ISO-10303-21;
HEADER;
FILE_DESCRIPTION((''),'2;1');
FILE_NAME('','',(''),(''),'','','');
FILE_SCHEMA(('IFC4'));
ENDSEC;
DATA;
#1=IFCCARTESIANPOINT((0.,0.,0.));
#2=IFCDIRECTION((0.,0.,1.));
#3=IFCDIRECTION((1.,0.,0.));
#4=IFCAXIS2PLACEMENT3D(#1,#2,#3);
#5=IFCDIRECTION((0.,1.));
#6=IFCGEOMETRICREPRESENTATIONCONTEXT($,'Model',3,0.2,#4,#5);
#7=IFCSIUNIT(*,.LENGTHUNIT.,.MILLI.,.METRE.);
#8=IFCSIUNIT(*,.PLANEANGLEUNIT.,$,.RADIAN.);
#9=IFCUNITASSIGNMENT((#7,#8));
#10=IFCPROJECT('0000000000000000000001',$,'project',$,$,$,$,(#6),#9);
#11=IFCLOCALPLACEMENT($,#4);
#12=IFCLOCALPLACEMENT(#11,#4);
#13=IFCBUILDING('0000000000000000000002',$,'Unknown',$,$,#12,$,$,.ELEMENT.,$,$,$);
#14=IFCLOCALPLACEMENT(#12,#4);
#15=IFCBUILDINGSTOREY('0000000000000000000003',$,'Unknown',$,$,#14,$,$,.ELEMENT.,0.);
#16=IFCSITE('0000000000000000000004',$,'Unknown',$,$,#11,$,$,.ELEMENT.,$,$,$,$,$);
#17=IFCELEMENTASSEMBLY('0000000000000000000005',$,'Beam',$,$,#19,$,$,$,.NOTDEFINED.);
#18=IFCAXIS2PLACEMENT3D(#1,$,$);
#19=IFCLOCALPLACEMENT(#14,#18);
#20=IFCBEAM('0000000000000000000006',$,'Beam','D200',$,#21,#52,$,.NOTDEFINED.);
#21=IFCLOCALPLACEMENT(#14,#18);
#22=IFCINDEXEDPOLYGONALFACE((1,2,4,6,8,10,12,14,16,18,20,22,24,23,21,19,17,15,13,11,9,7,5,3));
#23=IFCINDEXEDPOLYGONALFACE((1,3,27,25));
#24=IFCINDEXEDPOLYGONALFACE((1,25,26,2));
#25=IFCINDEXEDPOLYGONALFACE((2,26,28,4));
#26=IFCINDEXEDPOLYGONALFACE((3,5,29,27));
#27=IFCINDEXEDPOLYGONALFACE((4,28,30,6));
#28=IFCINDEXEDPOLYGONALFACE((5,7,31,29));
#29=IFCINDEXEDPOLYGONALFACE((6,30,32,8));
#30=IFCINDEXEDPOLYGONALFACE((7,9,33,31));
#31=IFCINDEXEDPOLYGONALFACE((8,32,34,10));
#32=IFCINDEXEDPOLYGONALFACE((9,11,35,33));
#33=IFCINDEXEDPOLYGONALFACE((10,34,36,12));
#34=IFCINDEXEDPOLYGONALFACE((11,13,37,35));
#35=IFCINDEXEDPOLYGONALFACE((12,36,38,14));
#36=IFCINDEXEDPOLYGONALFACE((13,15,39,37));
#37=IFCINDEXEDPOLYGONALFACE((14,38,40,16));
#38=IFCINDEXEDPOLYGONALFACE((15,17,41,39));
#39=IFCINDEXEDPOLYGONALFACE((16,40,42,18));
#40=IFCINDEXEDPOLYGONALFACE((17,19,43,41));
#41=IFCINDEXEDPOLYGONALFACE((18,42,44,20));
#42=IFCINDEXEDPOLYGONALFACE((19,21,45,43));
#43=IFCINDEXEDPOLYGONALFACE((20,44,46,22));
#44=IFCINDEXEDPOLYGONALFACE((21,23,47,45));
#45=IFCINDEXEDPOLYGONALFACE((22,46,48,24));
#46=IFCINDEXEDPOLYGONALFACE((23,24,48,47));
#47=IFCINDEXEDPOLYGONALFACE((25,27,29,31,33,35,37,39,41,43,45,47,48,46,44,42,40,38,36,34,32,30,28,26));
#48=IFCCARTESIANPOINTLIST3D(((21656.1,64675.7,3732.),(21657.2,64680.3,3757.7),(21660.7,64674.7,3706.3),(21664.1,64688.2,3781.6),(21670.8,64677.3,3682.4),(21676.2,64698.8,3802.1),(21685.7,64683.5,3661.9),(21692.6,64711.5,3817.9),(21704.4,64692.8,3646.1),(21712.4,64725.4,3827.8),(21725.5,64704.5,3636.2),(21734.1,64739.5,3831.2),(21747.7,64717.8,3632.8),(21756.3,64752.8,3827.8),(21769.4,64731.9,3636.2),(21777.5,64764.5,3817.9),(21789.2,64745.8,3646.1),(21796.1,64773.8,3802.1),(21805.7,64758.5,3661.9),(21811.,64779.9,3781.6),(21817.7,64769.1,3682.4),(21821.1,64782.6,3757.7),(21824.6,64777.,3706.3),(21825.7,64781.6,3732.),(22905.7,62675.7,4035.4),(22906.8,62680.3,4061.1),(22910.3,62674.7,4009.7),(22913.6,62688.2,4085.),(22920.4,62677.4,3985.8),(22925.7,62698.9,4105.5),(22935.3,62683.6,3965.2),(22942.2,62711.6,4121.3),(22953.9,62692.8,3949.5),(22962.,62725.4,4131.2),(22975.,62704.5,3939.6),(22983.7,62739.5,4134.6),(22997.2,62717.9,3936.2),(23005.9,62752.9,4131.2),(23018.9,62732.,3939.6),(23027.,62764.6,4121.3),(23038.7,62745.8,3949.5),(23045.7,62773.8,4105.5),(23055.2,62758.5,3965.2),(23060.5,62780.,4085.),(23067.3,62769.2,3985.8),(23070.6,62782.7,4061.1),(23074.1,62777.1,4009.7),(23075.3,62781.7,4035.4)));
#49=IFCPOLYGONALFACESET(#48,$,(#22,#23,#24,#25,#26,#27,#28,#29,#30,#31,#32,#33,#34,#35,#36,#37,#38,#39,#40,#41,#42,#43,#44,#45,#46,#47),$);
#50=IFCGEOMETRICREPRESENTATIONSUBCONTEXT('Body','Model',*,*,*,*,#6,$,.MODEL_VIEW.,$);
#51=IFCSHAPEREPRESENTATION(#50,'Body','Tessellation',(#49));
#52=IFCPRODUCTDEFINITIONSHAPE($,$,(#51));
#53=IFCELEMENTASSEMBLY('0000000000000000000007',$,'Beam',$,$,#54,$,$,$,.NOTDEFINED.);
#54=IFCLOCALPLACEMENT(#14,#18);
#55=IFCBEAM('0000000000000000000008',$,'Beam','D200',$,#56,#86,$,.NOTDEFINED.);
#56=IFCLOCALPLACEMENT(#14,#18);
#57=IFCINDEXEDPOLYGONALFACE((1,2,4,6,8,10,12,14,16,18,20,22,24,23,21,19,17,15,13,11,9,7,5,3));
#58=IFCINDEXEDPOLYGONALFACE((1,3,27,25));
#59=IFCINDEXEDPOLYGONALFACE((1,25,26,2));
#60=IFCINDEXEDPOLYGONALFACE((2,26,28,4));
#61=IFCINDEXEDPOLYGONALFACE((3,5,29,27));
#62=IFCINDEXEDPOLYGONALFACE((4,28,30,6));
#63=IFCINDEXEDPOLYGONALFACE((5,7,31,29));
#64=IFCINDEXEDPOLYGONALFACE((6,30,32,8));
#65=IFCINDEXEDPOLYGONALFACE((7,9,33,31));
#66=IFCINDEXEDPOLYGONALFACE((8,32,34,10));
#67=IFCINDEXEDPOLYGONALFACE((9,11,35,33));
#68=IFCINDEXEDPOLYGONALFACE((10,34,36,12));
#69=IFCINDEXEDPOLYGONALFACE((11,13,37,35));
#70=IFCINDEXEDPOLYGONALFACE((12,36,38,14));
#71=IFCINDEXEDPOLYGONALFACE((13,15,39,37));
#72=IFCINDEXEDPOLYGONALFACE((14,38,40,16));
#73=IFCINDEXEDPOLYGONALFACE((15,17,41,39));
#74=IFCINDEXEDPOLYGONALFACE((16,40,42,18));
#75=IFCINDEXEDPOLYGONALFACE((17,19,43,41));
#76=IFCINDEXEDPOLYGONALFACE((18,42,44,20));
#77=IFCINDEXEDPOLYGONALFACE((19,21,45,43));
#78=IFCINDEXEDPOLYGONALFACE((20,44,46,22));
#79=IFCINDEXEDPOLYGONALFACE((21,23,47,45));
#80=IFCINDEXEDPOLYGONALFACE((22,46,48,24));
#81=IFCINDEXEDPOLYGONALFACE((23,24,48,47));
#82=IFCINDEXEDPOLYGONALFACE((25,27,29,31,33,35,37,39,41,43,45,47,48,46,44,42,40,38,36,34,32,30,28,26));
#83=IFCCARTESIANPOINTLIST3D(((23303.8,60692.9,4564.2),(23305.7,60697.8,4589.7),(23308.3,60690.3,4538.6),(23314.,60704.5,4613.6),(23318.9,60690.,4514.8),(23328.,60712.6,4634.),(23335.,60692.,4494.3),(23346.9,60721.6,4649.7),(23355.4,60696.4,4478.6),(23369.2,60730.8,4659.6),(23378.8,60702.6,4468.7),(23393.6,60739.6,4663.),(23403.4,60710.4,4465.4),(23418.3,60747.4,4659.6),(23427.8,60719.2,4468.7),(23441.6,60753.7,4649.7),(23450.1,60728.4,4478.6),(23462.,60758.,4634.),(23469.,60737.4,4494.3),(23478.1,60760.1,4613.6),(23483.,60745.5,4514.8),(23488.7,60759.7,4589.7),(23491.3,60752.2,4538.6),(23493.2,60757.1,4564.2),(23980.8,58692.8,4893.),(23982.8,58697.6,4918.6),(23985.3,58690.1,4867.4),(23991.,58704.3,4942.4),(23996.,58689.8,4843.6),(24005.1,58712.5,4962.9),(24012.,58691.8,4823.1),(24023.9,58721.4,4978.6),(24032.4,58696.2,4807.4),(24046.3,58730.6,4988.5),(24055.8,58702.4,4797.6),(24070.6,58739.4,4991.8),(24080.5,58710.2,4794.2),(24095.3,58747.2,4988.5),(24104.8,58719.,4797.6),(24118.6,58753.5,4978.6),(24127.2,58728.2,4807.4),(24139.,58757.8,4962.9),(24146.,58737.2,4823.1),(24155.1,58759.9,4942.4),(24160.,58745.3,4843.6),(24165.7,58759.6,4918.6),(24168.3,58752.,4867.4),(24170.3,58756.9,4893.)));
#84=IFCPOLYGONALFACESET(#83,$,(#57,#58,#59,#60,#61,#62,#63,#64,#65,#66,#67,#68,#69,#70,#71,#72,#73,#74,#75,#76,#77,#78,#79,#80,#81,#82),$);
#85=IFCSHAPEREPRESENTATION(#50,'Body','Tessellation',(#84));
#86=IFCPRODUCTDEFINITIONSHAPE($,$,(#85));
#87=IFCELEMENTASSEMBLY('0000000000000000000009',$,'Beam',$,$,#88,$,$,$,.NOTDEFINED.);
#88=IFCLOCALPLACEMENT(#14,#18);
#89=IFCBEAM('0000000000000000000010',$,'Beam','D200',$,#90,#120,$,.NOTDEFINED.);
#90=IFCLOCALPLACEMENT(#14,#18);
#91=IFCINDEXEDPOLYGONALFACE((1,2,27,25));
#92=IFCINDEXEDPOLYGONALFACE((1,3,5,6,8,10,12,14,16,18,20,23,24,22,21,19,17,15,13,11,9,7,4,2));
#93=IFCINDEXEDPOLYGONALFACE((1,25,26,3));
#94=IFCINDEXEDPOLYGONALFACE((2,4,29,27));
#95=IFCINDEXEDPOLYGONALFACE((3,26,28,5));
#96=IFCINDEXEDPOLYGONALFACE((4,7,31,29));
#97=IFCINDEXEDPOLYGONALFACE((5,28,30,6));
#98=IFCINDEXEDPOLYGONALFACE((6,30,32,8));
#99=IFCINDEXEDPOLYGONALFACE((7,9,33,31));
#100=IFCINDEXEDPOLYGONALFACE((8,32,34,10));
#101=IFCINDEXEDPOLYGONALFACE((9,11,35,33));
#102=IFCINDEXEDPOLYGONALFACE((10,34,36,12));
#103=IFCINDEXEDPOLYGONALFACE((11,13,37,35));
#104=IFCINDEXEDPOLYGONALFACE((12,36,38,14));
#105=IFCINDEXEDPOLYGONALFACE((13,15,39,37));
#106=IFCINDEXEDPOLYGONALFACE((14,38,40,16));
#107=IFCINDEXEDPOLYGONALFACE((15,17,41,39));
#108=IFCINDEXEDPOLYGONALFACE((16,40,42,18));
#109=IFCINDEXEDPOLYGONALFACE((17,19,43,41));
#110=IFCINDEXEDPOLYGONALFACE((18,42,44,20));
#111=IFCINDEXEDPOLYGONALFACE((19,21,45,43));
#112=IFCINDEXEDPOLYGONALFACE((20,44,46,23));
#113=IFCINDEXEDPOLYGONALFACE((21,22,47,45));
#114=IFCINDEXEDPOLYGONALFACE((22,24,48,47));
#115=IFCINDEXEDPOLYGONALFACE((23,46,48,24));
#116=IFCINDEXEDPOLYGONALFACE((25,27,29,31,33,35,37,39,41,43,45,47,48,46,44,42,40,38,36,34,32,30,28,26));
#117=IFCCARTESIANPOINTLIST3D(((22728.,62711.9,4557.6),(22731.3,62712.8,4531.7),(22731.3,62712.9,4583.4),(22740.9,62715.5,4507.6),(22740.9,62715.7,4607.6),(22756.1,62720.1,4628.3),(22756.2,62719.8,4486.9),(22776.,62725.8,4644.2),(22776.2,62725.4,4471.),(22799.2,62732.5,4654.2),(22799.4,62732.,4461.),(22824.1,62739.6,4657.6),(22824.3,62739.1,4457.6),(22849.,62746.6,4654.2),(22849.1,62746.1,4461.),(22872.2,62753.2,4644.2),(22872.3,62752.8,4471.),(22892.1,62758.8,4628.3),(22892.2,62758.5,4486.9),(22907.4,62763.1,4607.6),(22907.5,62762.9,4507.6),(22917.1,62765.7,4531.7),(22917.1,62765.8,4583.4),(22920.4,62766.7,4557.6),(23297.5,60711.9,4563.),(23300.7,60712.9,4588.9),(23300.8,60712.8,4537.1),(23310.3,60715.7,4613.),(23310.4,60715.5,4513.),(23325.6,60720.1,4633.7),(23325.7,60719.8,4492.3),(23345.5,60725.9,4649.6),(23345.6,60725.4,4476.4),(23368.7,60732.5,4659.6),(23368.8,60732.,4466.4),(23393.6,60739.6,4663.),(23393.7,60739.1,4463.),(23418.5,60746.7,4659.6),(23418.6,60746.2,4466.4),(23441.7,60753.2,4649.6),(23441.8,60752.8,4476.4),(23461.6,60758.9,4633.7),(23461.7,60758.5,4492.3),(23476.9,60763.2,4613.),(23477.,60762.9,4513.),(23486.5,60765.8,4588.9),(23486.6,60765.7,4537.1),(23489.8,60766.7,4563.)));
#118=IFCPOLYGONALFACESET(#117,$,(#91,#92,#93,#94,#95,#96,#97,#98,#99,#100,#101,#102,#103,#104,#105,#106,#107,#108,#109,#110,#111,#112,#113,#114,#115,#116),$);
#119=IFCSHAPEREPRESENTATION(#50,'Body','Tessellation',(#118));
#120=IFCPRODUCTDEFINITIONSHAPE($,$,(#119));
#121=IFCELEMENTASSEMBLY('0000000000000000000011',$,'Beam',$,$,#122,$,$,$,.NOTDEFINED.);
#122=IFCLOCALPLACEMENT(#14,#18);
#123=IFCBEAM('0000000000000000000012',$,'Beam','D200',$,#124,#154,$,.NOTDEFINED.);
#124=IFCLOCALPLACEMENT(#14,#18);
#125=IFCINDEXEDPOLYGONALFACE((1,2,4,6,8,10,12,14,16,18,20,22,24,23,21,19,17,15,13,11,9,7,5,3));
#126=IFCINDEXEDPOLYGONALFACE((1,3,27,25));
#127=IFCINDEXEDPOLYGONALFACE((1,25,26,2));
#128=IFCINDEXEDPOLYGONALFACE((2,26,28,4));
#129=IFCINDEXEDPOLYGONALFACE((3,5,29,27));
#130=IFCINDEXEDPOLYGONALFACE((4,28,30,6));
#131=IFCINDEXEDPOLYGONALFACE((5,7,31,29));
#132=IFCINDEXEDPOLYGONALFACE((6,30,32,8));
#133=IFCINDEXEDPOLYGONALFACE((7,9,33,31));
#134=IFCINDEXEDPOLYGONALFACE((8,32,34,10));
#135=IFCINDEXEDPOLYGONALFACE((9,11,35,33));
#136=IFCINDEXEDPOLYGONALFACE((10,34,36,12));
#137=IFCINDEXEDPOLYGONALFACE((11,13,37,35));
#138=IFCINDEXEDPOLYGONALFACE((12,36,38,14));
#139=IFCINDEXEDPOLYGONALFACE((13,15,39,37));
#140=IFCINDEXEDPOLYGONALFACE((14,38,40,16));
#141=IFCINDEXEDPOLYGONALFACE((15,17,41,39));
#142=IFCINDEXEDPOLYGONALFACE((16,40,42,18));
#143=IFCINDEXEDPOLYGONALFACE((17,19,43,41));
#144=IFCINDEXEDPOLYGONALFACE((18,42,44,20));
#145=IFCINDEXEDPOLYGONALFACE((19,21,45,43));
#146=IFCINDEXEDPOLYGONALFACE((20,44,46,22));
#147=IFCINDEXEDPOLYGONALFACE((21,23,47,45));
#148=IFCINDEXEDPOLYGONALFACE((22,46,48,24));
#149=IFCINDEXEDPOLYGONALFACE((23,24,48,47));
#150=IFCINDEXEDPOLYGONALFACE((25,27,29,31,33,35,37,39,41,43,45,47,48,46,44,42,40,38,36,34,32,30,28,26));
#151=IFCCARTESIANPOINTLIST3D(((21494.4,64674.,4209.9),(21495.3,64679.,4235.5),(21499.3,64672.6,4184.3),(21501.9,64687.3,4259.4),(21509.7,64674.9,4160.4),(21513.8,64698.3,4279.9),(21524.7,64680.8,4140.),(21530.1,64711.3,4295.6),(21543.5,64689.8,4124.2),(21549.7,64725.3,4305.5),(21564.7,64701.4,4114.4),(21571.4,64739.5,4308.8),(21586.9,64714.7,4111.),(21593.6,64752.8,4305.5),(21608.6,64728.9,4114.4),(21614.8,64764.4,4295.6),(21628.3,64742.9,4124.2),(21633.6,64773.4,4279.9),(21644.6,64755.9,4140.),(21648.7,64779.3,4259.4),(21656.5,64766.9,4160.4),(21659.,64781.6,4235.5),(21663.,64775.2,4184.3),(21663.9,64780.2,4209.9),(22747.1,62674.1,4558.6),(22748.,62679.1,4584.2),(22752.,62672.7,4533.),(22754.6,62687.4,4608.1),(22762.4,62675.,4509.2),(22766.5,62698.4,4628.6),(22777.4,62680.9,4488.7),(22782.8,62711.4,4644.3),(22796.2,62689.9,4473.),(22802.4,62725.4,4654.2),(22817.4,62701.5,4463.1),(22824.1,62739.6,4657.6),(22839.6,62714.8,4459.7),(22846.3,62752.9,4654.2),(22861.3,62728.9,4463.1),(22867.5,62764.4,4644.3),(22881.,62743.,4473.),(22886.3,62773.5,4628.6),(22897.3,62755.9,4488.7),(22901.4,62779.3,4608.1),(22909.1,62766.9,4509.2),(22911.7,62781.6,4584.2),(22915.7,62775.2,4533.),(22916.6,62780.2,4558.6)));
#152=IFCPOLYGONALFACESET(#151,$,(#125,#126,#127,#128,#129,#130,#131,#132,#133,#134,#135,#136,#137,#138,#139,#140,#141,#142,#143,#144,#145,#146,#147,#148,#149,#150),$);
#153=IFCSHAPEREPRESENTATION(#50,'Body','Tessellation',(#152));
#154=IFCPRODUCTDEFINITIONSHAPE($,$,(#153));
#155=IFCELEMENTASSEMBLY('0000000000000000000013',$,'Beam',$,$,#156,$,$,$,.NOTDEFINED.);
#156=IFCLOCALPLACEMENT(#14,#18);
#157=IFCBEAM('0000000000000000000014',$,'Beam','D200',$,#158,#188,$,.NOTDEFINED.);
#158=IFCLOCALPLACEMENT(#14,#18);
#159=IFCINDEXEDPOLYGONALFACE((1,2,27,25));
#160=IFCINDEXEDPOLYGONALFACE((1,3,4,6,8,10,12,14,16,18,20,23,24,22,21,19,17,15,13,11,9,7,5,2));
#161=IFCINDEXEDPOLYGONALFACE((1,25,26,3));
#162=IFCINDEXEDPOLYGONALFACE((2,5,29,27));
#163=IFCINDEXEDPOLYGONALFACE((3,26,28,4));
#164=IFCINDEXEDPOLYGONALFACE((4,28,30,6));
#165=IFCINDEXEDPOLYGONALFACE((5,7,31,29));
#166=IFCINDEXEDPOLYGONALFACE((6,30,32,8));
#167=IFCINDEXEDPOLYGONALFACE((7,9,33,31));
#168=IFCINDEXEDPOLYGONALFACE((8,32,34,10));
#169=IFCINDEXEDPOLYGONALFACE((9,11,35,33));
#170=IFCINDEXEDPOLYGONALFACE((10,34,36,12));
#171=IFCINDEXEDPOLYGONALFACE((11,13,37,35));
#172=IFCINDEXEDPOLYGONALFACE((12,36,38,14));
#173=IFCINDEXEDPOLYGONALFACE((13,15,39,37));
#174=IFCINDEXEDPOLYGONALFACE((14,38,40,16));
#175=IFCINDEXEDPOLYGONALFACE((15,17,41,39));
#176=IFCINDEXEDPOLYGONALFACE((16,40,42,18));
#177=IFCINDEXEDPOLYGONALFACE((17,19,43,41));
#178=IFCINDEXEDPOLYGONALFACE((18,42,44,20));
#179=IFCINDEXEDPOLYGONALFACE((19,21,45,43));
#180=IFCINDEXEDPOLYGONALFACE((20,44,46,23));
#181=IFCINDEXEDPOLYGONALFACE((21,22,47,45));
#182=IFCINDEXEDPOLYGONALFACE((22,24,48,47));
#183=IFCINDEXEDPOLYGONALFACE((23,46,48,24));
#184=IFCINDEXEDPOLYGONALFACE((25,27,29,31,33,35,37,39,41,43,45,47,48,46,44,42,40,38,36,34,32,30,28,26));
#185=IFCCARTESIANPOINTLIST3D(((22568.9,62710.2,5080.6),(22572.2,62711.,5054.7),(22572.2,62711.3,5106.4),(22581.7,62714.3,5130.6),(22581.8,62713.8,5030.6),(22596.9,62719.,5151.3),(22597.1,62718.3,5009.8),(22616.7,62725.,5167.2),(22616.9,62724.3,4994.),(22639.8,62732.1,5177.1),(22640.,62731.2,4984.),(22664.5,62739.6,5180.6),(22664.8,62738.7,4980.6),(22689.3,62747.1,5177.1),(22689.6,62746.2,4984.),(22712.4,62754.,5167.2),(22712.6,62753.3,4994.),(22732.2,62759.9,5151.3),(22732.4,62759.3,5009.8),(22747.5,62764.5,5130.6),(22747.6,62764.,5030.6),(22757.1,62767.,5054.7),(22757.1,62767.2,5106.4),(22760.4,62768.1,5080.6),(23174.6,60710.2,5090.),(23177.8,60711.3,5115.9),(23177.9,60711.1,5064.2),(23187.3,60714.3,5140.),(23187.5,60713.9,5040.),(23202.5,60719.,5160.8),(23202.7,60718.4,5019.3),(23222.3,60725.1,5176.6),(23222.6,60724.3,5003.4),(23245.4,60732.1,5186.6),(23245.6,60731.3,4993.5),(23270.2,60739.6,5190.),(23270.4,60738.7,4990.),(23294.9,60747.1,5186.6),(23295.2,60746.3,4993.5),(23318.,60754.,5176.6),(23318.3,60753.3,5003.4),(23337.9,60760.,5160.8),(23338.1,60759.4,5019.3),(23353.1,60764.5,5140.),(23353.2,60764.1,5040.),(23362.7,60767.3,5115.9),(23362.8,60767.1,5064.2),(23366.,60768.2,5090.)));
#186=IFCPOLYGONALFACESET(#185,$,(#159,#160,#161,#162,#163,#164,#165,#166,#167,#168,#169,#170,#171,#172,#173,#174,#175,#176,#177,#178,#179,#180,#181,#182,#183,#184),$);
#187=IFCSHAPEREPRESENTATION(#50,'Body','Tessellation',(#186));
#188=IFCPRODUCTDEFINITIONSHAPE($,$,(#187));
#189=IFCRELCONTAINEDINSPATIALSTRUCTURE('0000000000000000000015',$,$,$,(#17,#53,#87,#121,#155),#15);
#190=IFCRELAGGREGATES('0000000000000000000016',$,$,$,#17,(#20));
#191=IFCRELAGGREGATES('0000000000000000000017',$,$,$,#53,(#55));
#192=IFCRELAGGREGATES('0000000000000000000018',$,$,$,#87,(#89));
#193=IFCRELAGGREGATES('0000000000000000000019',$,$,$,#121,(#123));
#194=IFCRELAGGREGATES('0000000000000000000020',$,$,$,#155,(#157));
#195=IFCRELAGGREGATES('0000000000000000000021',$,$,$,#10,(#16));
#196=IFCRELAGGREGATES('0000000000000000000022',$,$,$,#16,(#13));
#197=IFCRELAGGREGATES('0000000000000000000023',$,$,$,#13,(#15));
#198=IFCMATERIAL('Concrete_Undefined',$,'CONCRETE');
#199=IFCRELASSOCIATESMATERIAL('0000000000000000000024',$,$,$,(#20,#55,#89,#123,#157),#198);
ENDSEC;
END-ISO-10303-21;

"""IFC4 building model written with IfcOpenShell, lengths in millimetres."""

from ifc_helpers import new_model, si_unit, direction, frame, origin_with_axes, place, context, subcontext, project, spatial, line, indexed_curve, outline, extrude, material, element, aggregate, save


model = new_model("IFC4")

# Units and contexts
model_context = context("Model", 3, precision=0.2, world=origin_with_axes(), true_north=direction((0.0, 1.0)))
body_context = subcontext(model_context, "Body", "Model", "MODEL_VIEW")
ifc_project = project(units=[si_unit("LENGTHUNIT", "METRE", prefix="MILLI"), si_unit("PLANEANGLEUNIT", "RADIAN")], contexts=[model_context])

# Site, building, storey
site_placement = place(None, origin_with_axes())
site = spatial("IfcSite", under=ifc_project, at=site_placement, Name="Unknown", CompositionType="ELEMENT")
building_placement = place(site_placement, origin_with_axes())
building = spatial("IfcBuilding", under=site, at=building_placement, Name="Unknown", CompositionType="ELEMENT")
storey_placement = place(building_placement, origin_with_axes())
storey = spatial("IfcBuildingStorey", under=building, at=storey_placement, Name="Unknown", CompositionType="ELEMENT", Elevation=0.0)

# Element assemblies, beams
ifc_material = material(Name="Concrete_Undefined", Category="CONCRETE")
assembly_1_placement = place(storey_placement, frame((21740.9, 64728.6, 3732.0), z_axis=(-0.848074, -0.529878, 0.0), x_axis=(0.525546, -0.841141, 0.127603)))
assembly_1 = element("IfcElementAssembly", 1, at=assembly_1_placement, inside=storey, Name="Beam", PredefinedType="NOTDEFINED")
beam_1_placement = place(assembly_1_placement, origin_with_axes())
beam_1 = element("IfcBeam", 2, at=beam_1_placement, material=ifc_material, Name="Beam", Description="D200", PredefinedType="NOTDEFINED", context=body_context, shape_type="SolidModel", body=[
    extrude(outline(indexed_curve([(100.0, 0.0), (96.6, 25.9), (86.6, 50.0), (70.7, 70.7), (50.0, 86.6), (25.9, 96.6), (0.0, 100.0), (-25.9, 96.6), (-50.0, 86.6), (-70.7, 70.7), (-86.6, 50.0), (-96.6, 25.9), (-100.0, 0.0), (-96.6, -25.9), (-86.6, -50.0), (-70.7, -70.7), (-50.0, -86.6), (-25.9, -96.6), (0.0, -100.0), (25.9, -96.6), (50.0, -86.6), (70.7, -70.7), (86.6, -50.0), (96.6, -25.9)], segments=[line(1, 2, 3, 4, 5, 6, 7, 8, 9, 10, 11, 12, 13, 14, 15, 16, 17, 18, 19, 20, 21, 22, 23, 24, 1)])), frame((0.0, 0.0, 0.0), z_axis=(-1.0, 0.0, 0.0), x_axis=(0.0, 0.0, 1.0)), (0.0, 0.0, -1.0), 2377.6),
])
aggregate(assembly_1, [beam_1])
assembly_2_placement = place(storey_placement, frame((23398.5, 60725.0, 4564.2), z_axis=(-0.947211, -0.32061, 0.0), x_axis=(0.316791, -0.93593, 0.153875)))
assembly_2 = element("IfcElementAssembly", 3, at=assembly_2_placement, inside=storey, Name="Beam", PredefinedType="NOTDEFINED")
beam_2_placement = place(assembly_2_placement, origin_with_axes())
beam_2 = element("IfcBeam", 4, at=beam_2_placement, material=ifc_material, Name="Beam", Description="D200", PredefinedType="NOTDEFINED", context=body_context, shape_type="SolidModel", body=[
    extrude(outline(indexed_curve([(100.0, 0.0), (96.6, 25.9), (86.6, 50.0), (70.7, 70.7), (50.0, 86.6), (25.9, 96.6), (0.0, 100.0), (-25.9, 96.6), (-50.0, 86.6), (-70.7, 70.7), (-86.6, 50.0), (-96.6, 25.9), (-100.0, 0.0), (-96.6, -25.9), (-86.6, -50.0), (-70.7, -70.7), (-50.0, -86.6), (-25.9, -96.6), (0.0, -100.0), (25.9, -96.6), (50.0, -86.6), (70.7, -70.7), (86.6, -50.0), (96.6, -25.9)], segments=[line(1, 2, 3, 4, 5, 6, 7, 8, 9, 10, 11, 12, 13, 14, 15, 16, 17, 18, 19, 20, 21, 22, 23, 24, 1)])), frame((0.0, 0.0, 0.0), z_axis=(-1.0, 0.0, 0.0), x_axis=(0.0, 0.0, 1.0)), (0.0, 0.0, -1.0), 2137.1),
])
aggregate(assembly_2, [beam_2])
assembly_3_placement = place(storey_placement, frame((22824.2, 62739.3, 4557.6), z_axis=(-0.961772, -0.273852, 0.0), x_axis=(0.273851, -0.961769, 0.002601)))
assembly_3 = element("IfcElementAssembly", 5, at=assembly_3_placement, inside=storey, Name="Beam", PredefinedType="NOTDEFINED")
beam_3_placement = place(assembly_3_placement, origin_with_axes())
beam_3 = element("IfcBeam", 6, at=beam_3_placement, material=ifc_material, Name="Beam", Description="D200", PredefinedType="NOTDEFINED", context=body_context, shape_type="SolidModel", body=[
    extrude(outline(indexed_curve([(100.0, 0.0), (96.6, 25.9), (86.6, 50.0), (70.7, 70.7), (50.0, 86.6), (25.9, 96.6), (0.0, 100.0), (-25.9, 96.6), (-50.0, 86.6), (-70.7, 70.7), (-86.6, 50.0), (-96.6, 25.9), (-100.0, 0.0), (-96.6, -25.9), (-86.6, -50.0), (-70.7, -70.7), (-50.0, -86.6), (-25.9, -96.6), (0.0, -100.0), (25.9, -96.6), (50.0, -86.6), (70.7, -70.7), (86.6, -50.0), (96.6, -25.9)], segments=[line(1, 2, 3, 4, 5, 6, 7, 8, 9, 10, 11, 12, 13, 14, 15, 16, 17, 18, 19, 20, 21, 22, 23, 24, 1)])), frame((0.0, 0.0, 0.0), z_axis=(-1.0, 0.0, 0.0), x_axis=(0.0, 0.0, 1.0)), (0.0, 0.0, -1.0), 2079.5),
])
aggregate(assembly_3, [beam_3])
assembly_4_placement = place(storey_placement, frame((21579.2, 64727.1, 4209.9), z_axis=(-0.847475, -0.530836, 0.0), x_axis=(0.525133, -0.83837, 0.146187)))
assembly_4 = element("IfcElementAssembly", 7, at=assembly_4_placement, inside=storey, Name="Beam", PredefinedType="NOTDEFINED")
beam_4_placement = place(assembly_4_placement, origin_with_axes())
beam_4 = element("IfcBeam", 8, at=beam_4_placement, material=ifc_material, Name="Beam", Description="D200", PredefinedType="NOTDEFINED", context=body_context, shape_type="SolidModel", body=[
    extrude(outline(indexed_curve([(100.0, 0.0), (96.6, 25.9), (86.6, 50.0), (70.7, 70.7), (50.0, 86.6), (25.9, 96.6), (0.0, 100.0), (-25.9, 96.6), (-50.0, 86.6), (-70.7, 70.7), (-86.6, 50.0), (-96.6, 25.9), (-100.0, 0.0), (-96.6, -25.9), (-86.6, -50.0), (-70.7, -70.7), (-50.0, -86.6), (-25.9, -96.6), (0.0, -100.0), (25.9, -96.6), (50.0, -86.6), (70.7, -70.7), (86.6, -50.0), (96.6, -25.9)], segments=[line(1, 2, 3, 4, 5, 6, 7, 8, 9, 10, 11, 12, 13, 14, 15, 16, 17, 18, 19, 20, 21, 22, 23, 24, 1)])), frame((0.0, 0.0, 0.0), z_axis=(-1.0, 0.0, 0.0), x_axis=(0.0, 0.0, 1.0)), (0.0, 0.0, -1.0), 2385.5),
])
aggregate(assembly_4, [beam_4])
assembly_5_placement = place(storey_placement, frame((22664.7, 62739.1, 5080.6), z_axis=(-0.957079, -0.289827, 0.0), x_axis=(0.289824, -0.957069, 0.00454)))
assembly_5 = element("IfcElementAssembly", 9, at=assembly_5_placement, inside=storey, Name="Beam", PredefinedType="NOTDEFINED")
beam_5_placement = place(assembly_5_placement, origin_with_axes())
beam_5 = element("IfcBeam", 10, at=beam_5_placement, material=ifc_material, Name="Beam", Description="D200", PredefinedType="NOTDEFINED", context=body_context, shape_type="SolidModel", body=[
    extrude(outline(indexed_curve([(100.0, 0.0), (96.6, 25.9), (86.6, 50.0), (70.7, 70.7), (50.0, 86.6), (25.9, 96.6), (0.0, 100.0), (-25.9, 96.6), (-50.0, 86.6), (-70.7, 70.7), (-86.6, 50.0), (-96.6, 25.9), (-100.0, 0.0), (-96.6, -25.9), (-86.6, -50.0), (-70.7, -70.7), (-50.0, -86.6), (-25.9, -96.6), (0.0, -100.0), (25.9, -96.6), (50.0, -86.6), (70.7, -70.7), (86.6, -50.0), (96.6, -25.9)], segments=[line(1, 2, 3, 4, 5, 6, 7, 8, 9, 10, 11, 12, 13, 14, 15, 16, 17, 18, 19, 20, 21, 22, 23, 24, 1)])), frame((0.0, 0.0, 0.0), z_axis=(-1.0, 0.0, 0.0), x_axis=(0.0, 0.0, 1.0)), (0.0, 0.0, -1.0), 2089.7),
])
aggregate(assembly_5, [beam_5])

save(model, "model.ifc")
